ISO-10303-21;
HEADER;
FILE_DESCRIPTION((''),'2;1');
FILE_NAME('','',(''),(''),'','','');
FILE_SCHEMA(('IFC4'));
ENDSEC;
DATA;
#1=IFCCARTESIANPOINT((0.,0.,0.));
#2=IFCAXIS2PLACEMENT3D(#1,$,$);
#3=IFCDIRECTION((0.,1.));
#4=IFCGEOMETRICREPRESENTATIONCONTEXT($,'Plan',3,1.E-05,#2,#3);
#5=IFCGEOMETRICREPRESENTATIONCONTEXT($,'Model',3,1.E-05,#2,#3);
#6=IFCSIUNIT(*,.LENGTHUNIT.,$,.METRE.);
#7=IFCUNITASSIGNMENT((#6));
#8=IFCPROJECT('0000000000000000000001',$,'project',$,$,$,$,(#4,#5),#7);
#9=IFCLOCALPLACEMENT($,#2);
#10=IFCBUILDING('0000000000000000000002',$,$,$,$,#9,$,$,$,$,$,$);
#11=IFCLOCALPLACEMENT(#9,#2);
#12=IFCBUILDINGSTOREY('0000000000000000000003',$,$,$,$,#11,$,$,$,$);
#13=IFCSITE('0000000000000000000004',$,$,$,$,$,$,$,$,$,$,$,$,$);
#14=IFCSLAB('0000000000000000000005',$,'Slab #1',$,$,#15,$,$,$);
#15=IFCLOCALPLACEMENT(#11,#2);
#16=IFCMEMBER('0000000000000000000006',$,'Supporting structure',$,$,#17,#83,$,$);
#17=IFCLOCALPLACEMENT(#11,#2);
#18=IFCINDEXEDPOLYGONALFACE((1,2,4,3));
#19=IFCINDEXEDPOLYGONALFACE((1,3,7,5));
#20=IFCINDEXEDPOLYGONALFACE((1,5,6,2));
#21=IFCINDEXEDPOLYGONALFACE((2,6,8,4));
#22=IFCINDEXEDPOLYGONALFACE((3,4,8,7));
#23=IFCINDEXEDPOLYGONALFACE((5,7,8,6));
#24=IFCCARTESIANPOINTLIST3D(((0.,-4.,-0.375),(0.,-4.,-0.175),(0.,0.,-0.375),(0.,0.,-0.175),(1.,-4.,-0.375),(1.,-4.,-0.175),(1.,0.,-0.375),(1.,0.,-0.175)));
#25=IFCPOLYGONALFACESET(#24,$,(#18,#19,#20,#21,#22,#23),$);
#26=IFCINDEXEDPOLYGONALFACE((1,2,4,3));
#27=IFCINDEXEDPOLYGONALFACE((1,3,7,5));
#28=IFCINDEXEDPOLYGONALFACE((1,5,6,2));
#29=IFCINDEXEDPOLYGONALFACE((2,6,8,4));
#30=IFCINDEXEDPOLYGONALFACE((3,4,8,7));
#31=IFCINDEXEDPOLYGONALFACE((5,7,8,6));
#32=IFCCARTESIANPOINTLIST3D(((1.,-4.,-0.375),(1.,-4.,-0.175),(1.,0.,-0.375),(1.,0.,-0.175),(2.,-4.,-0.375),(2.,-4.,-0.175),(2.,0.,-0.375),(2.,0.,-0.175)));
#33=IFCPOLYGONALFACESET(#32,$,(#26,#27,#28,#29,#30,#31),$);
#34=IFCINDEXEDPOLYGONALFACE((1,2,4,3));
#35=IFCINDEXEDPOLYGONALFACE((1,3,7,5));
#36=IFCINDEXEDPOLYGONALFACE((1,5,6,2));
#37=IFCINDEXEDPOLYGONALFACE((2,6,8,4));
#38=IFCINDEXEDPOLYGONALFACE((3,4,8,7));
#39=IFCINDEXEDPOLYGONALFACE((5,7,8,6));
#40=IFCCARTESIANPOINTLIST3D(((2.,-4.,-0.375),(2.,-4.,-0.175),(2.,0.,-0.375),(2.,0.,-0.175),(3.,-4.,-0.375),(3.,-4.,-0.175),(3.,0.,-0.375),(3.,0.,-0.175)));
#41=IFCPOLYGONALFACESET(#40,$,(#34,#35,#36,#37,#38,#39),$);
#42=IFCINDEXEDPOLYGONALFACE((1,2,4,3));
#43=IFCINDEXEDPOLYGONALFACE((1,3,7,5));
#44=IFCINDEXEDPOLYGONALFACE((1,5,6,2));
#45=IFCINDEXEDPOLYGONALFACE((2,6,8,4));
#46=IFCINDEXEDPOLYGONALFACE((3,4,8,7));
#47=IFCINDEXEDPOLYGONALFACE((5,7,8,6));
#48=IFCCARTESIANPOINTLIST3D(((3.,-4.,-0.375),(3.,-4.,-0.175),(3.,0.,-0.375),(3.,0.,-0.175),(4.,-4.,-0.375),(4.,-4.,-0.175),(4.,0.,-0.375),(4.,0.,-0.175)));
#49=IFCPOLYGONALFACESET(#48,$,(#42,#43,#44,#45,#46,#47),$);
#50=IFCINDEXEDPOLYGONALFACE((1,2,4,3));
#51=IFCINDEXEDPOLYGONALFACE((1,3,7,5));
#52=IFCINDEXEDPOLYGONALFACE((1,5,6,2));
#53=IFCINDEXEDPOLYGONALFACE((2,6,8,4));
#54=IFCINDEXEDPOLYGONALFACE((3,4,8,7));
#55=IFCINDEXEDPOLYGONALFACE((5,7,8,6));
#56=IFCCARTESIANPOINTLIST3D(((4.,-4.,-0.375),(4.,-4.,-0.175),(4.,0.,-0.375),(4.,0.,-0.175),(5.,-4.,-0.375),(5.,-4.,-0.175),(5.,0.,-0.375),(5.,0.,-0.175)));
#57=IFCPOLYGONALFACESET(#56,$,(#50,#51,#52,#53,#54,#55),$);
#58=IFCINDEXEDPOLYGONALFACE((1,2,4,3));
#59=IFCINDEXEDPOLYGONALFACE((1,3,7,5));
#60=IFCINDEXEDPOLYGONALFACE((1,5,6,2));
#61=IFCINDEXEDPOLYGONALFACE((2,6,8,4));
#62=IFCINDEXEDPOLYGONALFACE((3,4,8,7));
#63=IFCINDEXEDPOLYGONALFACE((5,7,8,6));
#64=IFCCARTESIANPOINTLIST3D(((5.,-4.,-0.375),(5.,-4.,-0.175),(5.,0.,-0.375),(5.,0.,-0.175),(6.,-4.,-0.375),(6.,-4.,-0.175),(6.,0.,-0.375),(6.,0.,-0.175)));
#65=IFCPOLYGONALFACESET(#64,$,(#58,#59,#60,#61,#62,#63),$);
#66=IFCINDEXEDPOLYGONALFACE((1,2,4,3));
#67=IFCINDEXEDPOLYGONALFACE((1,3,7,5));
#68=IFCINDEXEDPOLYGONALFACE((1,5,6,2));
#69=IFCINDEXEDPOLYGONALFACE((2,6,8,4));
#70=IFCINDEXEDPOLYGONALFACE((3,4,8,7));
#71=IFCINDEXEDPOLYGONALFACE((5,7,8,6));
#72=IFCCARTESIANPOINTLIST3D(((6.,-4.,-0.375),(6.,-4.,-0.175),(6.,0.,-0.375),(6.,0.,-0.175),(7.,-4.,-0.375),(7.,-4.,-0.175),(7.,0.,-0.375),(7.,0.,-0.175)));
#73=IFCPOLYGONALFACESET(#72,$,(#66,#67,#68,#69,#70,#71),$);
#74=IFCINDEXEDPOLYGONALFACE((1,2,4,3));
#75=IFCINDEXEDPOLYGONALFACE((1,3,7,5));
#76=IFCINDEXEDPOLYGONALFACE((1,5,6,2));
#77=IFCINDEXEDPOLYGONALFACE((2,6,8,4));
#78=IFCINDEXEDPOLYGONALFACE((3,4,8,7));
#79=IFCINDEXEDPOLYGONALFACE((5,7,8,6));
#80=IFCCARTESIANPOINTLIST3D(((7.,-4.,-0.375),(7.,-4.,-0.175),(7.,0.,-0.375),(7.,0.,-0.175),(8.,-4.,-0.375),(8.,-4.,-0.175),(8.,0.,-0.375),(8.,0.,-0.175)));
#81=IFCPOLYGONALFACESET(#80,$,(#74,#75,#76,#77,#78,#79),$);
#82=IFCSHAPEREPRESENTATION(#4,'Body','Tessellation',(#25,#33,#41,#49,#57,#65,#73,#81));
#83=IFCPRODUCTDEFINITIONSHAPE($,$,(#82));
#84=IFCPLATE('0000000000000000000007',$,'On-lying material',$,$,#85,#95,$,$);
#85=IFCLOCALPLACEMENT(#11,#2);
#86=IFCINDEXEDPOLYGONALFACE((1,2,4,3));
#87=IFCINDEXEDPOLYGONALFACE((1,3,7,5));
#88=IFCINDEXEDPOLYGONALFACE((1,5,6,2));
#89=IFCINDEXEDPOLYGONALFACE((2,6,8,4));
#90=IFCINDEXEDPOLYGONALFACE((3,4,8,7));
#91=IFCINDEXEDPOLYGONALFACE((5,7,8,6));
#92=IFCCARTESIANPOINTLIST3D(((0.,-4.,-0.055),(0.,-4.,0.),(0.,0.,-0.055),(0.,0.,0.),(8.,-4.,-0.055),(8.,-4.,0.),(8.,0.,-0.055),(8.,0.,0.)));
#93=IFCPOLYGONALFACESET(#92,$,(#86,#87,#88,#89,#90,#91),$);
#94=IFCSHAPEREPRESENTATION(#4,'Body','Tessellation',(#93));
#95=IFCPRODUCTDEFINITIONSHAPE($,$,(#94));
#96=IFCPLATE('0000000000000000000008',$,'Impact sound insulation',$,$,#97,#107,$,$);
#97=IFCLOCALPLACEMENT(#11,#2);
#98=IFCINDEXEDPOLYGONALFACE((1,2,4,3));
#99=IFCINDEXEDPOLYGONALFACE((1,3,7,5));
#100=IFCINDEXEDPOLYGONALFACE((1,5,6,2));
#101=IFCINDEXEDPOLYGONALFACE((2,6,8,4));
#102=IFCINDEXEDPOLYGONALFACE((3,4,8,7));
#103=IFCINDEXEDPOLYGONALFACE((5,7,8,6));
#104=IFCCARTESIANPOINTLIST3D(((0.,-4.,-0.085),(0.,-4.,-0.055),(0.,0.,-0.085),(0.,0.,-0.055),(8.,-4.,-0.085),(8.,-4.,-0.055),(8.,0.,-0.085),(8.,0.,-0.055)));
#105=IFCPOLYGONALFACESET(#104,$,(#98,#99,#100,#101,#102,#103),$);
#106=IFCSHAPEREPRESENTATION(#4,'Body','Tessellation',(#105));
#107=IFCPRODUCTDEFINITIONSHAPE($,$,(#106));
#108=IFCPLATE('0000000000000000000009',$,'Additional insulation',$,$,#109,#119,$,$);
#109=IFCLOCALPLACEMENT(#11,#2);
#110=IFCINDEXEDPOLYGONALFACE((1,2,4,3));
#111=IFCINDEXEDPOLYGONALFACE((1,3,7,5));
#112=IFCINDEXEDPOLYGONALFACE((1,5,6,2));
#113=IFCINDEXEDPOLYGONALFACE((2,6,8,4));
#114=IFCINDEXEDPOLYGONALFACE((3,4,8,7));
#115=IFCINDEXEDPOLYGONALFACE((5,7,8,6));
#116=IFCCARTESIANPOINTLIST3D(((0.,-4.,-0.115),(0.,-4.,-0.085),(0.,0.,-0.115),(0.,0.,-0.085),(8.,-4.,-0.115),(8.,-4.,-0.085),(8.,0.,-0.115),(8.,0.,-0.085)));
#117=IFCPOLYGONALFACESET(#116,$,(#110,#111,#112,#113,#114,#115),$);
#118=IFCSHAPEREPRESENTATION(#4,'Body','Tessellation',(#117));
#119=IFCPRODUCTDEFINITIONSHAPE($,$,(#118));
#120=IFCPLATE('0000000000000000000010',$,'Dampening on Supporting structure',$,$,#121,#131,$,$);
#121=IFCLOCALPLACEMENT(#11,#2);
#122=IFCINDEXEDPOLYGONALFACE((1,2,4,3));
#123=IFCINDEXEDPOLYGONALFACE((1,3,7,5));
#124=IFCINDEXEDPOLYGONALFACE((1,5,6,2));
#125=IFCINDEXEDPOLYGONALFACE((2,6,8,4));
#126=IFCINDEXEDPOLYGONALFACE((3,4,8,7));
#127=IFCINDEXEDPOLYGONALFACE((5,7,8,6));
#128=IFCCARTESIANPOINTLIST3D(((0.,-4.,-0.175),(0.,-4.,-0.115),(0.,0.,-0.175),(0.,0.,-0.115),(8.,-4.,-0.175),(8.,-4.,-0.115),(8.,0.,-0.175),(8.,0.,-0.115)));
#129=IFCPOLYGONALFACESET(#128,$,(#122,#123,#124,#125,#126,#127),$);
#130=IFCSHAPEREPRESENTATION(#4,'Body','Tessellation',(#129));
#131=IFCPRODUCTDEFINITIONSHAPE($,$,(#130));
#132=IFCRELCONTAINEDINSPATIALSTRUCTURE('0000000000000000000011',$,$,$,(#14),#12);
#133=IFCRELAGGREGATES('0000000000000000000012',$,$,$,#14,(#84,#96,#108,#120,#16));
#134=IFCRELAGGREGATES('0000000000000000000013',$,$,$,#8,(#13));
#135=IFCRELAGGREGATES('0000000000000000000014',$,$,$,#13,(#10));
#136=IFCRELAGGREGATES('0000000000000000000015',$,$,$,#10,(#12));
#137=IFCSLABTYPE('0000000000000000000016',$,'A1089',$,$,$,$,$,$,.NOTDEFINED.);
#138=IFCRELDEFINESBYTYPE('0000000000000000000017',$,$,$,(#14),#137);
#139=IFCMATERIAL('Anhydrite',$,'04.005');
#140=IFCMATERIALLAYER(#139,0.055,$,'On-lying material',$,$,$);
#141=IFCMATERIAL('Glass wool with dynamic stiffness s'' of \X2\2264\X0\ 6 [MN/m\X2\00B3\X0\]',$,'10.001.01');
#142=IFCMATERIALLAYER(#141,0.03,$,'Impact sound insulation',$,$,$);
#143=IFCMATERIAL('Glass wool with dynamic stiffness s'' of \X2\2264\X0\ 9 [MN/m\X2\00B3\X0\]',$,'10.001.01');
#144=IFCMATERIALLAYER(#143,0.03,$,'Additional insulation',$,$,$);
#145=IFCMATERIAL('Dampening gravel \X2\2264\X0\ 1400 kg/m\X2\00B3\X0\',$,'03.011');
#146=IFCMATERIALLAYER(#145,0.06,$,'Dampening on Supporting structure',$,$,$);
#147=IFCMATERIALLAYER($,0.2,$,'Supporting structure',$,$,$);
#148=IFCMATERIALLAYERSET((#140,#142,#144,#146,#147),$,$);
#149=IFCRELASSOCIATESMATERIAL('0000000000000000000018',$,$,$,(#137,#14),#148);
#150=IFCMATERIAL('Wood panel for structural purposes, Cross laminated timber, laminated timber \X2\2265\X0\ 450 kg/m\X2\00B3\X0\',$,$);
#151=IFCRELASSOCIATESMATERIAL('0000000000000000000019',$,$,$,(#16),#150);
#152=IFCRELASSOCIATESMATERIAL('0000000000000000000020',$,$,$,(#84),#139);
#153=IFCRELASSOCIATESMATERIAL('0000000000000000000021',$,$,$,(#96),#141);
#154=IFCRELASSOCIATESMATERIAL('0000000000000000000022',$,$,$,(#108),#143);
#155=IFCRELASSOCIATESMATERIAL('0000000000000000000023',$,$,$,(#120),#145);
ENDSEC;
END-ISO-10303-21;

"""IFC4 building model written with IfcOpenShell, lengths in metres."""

from ifc_helpers import new_model, si_unit, direction, frame, frame_2d, origin, origin_with_axes, place, context, project, spatial, rectangle, extrude, material, layer, layer_set, type_object, element, aggregate, save


model = new_model("IFC4")

# Units and contexts
plan_context = context("Plan", 3, precision=1e-05, world=origin(), true_north=direction((0.0, 1.0)))
model_context = context("Model", 3, precision=1e-05, world=origin(), true_north=direction((0.0, 1.0)))
ifc_project = project(units=[si_unit("LENGTHUNIT", "METRE")], contexts=[plan_context, model_context])

# Site, building, storey
site = spatial("IfcSite", under=ifc_project)
building_placement = place(None, origin())
building = spatial("IfcBuilding", under=site, at=building_placement)
storey_placement = place(building_placement, origin())
storey = spatial("IfcBuildingStorey", under=building, at=storey_placement)

# Slab, member, plates
ifc_material_1 = material(Name="Anhydrite", Category="04.005")
ifc_layer_1 = layer(ifc_material_1, 0.055, Name="On-lying material")
ifc_material_2 = material(Name="Glass wool with dynamic stiffness s' of ≤ 6 [MN/m³]", Category="10.001.01")
ifc_layer_2 = layer(ifc_material_2, 0.03, Name="Impact sound insulation")
ifc_material_3 = material(Name="Glass wool with dynamic stiffness s' of ≤ 9 [MN/m³]", Category="10.001.01")
ifc_layer_3 = layer(ifc_material_3, 0.03, Name="Additional insulation")
ifc_material_4 = material(Name="Dampening gravel ≤ 1400 kg/m³", Category="03.011")
ifc_layer_4 = layer(ifc_material_4, 0.06, Name="Dampening on Supporting structure")
ifc_layer_5 = layer(None, 0.2, Name="Supporting structure")
ifc_layer_set = layer_set([ifc_layer_1, ifc_layer_2, ifc_layer_3, ifc_layer_4, ifc_layer_5])
slab_type = type_object("IfcSlabType", Name="A1089", PredefinedType="NOTDEFINED", material=ifc_layer_set)
slab_placement = place(None, frame((0.0, 0.0, 0.0), z_axis=(0.0, 0.0, -1.0), x_axis=(1.0, 0.0, 0.0)))
slab = element("IfcSlab", 1, at=slab_placement, inside=storey, type_object=slab_type, material=ifc_layer_set, Name="Slab #1")
ifc_material_5 = material(Name="Wood panel for structural purposes, Cross laminated timber, laminated timber ≥ 450 kg/m³")
member_placement = place(slab_placement, origin())
member = element("IfcMember", 2, at=member_placement, material=ifc_material_5, Name="Supporting structure", context=plan_context, shape_type="SweptSolid", body=[
    extrude(rectangle(XDim=1.0, YDim=0.2, at=frame_2d((0.5, 0.1), x_axis=(1.0, 0.0))), frame((0.0, 4.0, 0.175), z_axis=(0.0, -1.0, 0.0), x_axis=(1.0, 0.0, 0.0)), (0.0, 0.0, 1.0), 4.0),
    extrude(rectangle(XDim=1.0, YDim=0.2, at=frame_2d((0.5, 0.1), x_axis=(1.0, 0.0))), frame((1.0, 4.0, 0.175), z_axis=(0.0, -1.0, 0.0), x_axis=(1.0, 0.0, 0.0)), (0.0, 0.0, 1.0), 4.0),
    extrude(rectangle(XDim=1.0, YDim=0.2, at=frame_2d((0.5, 0.1), x_axis=(1.0, 0.0))), frame((2.0, 4.0, 0.175), z_axis=(0.0, -1.0, 0.0), x_axis=(1.0, 0.0, 0.0)), (0.0, 0.0, 1.0), 4.0),
    extrude(rectangle(XDim=1.0, YDim=0.2, at=frame_2d((0.5, 0.1), x_axis=(1.0, 0.0))), frame((3.0, 4.0, 0.175), z_axis=(0.0, -1.0, 0.0), x_axis=(1.0, 0.0, 0.0)), (0.0, 0.0, 1.0), 4.0),
    extrude(rectangle(XDim=1.0, YDim=0.2, at=frame_2d((0.5, 0.1), x_axis=(1.0, 0.0))), frame((4.0, 4.0, 0.175), z_axis=(0.0, -1.0, 0.0), x_axis=(1.0, 0.0, 0.0)), (0.0, 0.0, 1.0), 4.0),
    extrude(rectangle(XDim=1.0, YDim=0.2, at=frame_2d((0.5, 0.1), x_axis=(1.0, 0.0))), frame((5.0, 4.0, 0.175), z_axis=(0.0, -1.0, 0.0), x_axis=(1.0, 0.0, 0.0)), (0.0, 0.0, 1.0), 4.0),
    extrude(rectangle(XDim=1.0, YDim=0.2, at=frame_2d((0.5, 0.1), x_axis=(1.0, 0.0))), frame((6.0, 4.0, 0.175), z_axis=(0.0, -1.0, 0.0), x_axis=(1.0, 0.0, 0.0)), (0.0, 0.0, 1.0), 4.0),
    extrude(rectangle(XDim=1.0, YDim=0.2, at=frame_2d((0.5, 0.1), x_axis=(1.0, 0.0))), frame((7.0, 4.0, 0.175), z_axis=(0.0, -1.0, 0.0), x_axis=(1.0, 0.0, 0.0)), (0.0, 0.0, 1.0), 4.0),
])
plate_1_placement = place(slab_placement, origin())
plate_1 = element("IfcPlate", 3, at=plate_1_placement, material=ifc_material_1, Name="On-lying material", context=plan_context, shape_type="SweptSolid", body=[
    extrude(rectangle(XDim=8.0, YDim=4.0, at=frame_2d((4.0, 2.0), x_axis=(1.0, 0.0))), origin_with_axes(), (0.0, 0.0, 1.0), 0.055),
])
plate_2_placement = place(slab_placement, origin())
plate_2 = element("IfcPlate", 4, at=plate_2_placement, material=ifc_material_2, Name="Impact sound insulation", context=plan_context, shape_type="SweptSolid", body=[
    extrude(rectangle(XDim=8.0, YDim=4.0, at=frame_2d((4.0, 2.0), x_axis=(1.0, 0.0))), frame((0.0, 0.0, 0.055), z_axis=(0.0, 0.0, 1.0), x_axis=(1.0, 0.0, 0.0)), (0.0, 0.0, 1.0), 0.03),
])
plate_3_placement = place(slab_placement, origin())
plate_3 = element("IfcPlate", 5, at=plate_3_placement, material=ifc_material_3, Name="Additional insulation", context=plan_context, shape_type="SweptSolid", body=[
    extrude(rectangle(XDim=8.0, YDim=4.0, at=frame_2d((4.0, 2.0), x_axis=(1.0, 0.0))), frame((0.0, 0.0, 0.085), z_axis=(0.0, 0.0, 1.0), x_axis=(1.0, 0.0, 0.0)), (0.0, 0.0, 1.0), 0.03),
])
plate_4_placement = place(slab_placement, origin())
plate_4 = element("IfcPlate", 6, at=plate_4_placement, material=ifc_material_4, Name="Dampening on Supporting structure", context=plan_context, shape_type="SweptSolid", body=[
    extrude(rectangle(XDim=8.0, YDim=4.0, at=frame_2d((4.0, 2.0), x_axis=(1.0, 0.0))), frame((0.0, 0.0, 0.115), z_axis=(0.0, 0.0, 1.0), x_axis=(1.0, 0.0, 0.0)), (0.0, 0.0, 1.0), 0.06),
])
aggregate(slab, [plate_1, plate_2, plate_3, plate_4, member])

save(model, "model.ifc")
